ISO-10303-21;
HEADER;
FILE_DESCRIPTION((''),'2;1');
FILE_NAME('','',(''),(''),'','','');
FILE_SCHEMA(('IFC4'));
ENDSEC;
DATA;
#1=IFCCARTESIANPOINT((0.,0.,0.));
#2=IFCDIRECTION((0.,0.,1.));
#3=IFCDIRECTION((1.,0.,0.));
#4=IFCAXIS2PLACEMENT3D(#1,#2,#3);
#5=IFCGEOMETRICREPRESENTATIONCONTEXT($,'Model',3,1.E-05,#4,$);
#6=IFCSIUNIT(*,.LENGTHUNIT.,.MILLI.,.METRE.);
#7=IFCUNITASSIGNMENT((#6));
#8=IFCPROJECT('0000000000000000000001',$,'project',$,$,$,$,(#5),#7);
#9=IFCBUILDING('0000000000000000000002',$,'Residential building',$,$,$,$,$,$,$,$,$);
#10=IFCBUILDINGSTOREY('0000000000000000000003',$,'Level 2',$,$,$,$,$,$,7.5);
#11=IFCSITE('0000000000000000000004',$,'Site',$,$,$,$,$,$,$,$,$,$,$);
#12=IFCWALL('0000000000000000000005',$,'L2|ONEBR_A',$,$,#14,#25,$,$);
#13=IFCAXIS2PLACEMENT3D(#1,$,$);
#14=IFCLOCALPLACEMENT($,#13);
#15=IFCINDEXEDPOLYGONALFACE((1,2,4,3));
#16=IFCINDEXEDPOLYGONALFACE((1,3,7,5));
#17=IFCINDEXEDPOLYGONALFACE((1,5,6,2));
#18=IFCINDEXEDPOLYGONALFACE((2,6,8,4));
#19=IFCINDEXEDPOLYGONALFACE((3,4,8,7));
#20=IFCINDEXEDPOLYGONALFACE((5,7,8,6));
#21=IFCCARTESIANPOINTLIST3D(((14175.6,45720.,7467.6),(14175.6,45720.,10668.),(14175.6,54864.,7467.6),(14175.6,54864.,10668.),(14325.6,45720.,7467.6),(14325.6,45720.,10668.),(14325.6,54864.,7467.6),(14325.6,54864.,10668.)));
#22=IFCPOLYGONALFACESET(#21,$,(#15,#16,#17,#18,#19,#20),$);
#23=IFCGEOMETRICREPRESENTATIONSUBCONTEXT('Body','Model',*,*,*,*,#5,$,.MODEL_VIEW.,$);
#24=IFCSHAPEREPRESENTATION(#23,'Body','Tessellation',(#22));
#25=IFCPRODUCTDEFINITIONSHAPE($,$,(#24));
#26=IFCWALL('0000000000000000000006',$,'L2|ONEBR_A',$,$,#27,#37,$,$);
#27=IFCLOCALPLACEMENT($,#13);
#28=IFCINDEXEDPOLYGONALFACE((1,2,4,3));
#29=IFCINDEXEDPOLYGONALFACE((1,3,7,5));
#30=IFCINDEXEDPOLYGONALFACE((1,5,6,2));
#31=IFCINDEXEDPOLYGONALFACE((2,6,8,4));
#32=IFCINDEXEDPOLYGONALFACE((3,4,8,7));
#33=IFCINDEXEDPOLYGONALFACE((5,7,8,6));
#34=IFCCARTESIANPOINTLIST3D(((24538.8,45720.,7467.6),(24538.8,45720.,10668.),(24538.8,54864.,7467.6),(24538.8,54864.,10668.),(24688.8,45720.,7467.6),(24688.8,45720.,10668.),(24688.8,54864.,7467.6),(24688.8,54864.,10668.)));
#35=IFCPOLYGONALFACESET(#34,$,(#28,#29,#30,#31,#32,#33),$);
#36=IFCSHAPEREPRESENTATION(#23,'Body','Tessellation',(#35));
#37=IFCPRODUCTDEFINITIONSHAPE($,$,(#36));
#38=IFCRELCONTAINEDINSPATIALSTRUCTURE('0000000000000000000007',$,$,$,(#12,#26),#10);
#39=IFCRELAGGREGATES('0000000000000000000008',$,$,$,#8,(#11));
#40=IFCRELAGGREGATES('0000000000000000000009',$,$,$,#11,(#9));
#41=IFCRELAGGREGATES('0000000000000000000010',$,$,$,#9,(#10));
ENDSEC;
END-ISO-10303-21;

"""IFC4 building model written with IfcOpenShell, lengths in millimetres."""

from ifc_helpers import new_model, si_unit, frame, origin_with_axes, place, context, subcontext, project, spatial, indexed_curve, outline, extrude, element, save


model = new_model("IFC4")

# Units and contexts
model_context = context("Model", 3, precision=1e-05, world=origin_with_axes())
body_context = subcontext(model_context, "Body", "Model", "MODEL_VIEW")
ifc_project = project(units=[si_unit("LENGTHUNIT", "METRE", prefix="MILLI")], contexts=[model_context])

# Site, building, storey
site = spatial("IfcSite", under=ifc_project, Name="Site")
building = spatial("IfcBuilding", under=site, Name="Residential building")
storey = spatial("IfcBuildingStorey", under=building, Name="Level 2", Elevation=7.5)

# Walls
for number, where, z_axis, x_axis, name in (
    (1, (14325.6, 45720.0, 7467.6), (0.0, 0.0, 1.0), (0.0, 1.0, 0.0), "L2|ONEBR_A"),
    (2, (24688.8, 45720.0, 7467.6), (0.0, 0.0, 1.0), (0.0, 1.0, 0.0), "L2|ONEBR_A"),
):
    element("IfcWall", number, at=place(None, frame(where, z_axis=z_axis, x_axis=x_axis)), inside=storey, Name=name, context=body_context, shape_type="SweptSolid", body=[
        extrude(outline(indexed_curve([(0.0, 0.0), (0.0, 150.0), (9144.0, 150.0), (9144.0, 0.0), (0.0, 0.0)], self_intersect=False)), origin_with_axes(), (0.0, 0.0, 1.0), 3200.4),
    ])

save(model, "model.ifc")
